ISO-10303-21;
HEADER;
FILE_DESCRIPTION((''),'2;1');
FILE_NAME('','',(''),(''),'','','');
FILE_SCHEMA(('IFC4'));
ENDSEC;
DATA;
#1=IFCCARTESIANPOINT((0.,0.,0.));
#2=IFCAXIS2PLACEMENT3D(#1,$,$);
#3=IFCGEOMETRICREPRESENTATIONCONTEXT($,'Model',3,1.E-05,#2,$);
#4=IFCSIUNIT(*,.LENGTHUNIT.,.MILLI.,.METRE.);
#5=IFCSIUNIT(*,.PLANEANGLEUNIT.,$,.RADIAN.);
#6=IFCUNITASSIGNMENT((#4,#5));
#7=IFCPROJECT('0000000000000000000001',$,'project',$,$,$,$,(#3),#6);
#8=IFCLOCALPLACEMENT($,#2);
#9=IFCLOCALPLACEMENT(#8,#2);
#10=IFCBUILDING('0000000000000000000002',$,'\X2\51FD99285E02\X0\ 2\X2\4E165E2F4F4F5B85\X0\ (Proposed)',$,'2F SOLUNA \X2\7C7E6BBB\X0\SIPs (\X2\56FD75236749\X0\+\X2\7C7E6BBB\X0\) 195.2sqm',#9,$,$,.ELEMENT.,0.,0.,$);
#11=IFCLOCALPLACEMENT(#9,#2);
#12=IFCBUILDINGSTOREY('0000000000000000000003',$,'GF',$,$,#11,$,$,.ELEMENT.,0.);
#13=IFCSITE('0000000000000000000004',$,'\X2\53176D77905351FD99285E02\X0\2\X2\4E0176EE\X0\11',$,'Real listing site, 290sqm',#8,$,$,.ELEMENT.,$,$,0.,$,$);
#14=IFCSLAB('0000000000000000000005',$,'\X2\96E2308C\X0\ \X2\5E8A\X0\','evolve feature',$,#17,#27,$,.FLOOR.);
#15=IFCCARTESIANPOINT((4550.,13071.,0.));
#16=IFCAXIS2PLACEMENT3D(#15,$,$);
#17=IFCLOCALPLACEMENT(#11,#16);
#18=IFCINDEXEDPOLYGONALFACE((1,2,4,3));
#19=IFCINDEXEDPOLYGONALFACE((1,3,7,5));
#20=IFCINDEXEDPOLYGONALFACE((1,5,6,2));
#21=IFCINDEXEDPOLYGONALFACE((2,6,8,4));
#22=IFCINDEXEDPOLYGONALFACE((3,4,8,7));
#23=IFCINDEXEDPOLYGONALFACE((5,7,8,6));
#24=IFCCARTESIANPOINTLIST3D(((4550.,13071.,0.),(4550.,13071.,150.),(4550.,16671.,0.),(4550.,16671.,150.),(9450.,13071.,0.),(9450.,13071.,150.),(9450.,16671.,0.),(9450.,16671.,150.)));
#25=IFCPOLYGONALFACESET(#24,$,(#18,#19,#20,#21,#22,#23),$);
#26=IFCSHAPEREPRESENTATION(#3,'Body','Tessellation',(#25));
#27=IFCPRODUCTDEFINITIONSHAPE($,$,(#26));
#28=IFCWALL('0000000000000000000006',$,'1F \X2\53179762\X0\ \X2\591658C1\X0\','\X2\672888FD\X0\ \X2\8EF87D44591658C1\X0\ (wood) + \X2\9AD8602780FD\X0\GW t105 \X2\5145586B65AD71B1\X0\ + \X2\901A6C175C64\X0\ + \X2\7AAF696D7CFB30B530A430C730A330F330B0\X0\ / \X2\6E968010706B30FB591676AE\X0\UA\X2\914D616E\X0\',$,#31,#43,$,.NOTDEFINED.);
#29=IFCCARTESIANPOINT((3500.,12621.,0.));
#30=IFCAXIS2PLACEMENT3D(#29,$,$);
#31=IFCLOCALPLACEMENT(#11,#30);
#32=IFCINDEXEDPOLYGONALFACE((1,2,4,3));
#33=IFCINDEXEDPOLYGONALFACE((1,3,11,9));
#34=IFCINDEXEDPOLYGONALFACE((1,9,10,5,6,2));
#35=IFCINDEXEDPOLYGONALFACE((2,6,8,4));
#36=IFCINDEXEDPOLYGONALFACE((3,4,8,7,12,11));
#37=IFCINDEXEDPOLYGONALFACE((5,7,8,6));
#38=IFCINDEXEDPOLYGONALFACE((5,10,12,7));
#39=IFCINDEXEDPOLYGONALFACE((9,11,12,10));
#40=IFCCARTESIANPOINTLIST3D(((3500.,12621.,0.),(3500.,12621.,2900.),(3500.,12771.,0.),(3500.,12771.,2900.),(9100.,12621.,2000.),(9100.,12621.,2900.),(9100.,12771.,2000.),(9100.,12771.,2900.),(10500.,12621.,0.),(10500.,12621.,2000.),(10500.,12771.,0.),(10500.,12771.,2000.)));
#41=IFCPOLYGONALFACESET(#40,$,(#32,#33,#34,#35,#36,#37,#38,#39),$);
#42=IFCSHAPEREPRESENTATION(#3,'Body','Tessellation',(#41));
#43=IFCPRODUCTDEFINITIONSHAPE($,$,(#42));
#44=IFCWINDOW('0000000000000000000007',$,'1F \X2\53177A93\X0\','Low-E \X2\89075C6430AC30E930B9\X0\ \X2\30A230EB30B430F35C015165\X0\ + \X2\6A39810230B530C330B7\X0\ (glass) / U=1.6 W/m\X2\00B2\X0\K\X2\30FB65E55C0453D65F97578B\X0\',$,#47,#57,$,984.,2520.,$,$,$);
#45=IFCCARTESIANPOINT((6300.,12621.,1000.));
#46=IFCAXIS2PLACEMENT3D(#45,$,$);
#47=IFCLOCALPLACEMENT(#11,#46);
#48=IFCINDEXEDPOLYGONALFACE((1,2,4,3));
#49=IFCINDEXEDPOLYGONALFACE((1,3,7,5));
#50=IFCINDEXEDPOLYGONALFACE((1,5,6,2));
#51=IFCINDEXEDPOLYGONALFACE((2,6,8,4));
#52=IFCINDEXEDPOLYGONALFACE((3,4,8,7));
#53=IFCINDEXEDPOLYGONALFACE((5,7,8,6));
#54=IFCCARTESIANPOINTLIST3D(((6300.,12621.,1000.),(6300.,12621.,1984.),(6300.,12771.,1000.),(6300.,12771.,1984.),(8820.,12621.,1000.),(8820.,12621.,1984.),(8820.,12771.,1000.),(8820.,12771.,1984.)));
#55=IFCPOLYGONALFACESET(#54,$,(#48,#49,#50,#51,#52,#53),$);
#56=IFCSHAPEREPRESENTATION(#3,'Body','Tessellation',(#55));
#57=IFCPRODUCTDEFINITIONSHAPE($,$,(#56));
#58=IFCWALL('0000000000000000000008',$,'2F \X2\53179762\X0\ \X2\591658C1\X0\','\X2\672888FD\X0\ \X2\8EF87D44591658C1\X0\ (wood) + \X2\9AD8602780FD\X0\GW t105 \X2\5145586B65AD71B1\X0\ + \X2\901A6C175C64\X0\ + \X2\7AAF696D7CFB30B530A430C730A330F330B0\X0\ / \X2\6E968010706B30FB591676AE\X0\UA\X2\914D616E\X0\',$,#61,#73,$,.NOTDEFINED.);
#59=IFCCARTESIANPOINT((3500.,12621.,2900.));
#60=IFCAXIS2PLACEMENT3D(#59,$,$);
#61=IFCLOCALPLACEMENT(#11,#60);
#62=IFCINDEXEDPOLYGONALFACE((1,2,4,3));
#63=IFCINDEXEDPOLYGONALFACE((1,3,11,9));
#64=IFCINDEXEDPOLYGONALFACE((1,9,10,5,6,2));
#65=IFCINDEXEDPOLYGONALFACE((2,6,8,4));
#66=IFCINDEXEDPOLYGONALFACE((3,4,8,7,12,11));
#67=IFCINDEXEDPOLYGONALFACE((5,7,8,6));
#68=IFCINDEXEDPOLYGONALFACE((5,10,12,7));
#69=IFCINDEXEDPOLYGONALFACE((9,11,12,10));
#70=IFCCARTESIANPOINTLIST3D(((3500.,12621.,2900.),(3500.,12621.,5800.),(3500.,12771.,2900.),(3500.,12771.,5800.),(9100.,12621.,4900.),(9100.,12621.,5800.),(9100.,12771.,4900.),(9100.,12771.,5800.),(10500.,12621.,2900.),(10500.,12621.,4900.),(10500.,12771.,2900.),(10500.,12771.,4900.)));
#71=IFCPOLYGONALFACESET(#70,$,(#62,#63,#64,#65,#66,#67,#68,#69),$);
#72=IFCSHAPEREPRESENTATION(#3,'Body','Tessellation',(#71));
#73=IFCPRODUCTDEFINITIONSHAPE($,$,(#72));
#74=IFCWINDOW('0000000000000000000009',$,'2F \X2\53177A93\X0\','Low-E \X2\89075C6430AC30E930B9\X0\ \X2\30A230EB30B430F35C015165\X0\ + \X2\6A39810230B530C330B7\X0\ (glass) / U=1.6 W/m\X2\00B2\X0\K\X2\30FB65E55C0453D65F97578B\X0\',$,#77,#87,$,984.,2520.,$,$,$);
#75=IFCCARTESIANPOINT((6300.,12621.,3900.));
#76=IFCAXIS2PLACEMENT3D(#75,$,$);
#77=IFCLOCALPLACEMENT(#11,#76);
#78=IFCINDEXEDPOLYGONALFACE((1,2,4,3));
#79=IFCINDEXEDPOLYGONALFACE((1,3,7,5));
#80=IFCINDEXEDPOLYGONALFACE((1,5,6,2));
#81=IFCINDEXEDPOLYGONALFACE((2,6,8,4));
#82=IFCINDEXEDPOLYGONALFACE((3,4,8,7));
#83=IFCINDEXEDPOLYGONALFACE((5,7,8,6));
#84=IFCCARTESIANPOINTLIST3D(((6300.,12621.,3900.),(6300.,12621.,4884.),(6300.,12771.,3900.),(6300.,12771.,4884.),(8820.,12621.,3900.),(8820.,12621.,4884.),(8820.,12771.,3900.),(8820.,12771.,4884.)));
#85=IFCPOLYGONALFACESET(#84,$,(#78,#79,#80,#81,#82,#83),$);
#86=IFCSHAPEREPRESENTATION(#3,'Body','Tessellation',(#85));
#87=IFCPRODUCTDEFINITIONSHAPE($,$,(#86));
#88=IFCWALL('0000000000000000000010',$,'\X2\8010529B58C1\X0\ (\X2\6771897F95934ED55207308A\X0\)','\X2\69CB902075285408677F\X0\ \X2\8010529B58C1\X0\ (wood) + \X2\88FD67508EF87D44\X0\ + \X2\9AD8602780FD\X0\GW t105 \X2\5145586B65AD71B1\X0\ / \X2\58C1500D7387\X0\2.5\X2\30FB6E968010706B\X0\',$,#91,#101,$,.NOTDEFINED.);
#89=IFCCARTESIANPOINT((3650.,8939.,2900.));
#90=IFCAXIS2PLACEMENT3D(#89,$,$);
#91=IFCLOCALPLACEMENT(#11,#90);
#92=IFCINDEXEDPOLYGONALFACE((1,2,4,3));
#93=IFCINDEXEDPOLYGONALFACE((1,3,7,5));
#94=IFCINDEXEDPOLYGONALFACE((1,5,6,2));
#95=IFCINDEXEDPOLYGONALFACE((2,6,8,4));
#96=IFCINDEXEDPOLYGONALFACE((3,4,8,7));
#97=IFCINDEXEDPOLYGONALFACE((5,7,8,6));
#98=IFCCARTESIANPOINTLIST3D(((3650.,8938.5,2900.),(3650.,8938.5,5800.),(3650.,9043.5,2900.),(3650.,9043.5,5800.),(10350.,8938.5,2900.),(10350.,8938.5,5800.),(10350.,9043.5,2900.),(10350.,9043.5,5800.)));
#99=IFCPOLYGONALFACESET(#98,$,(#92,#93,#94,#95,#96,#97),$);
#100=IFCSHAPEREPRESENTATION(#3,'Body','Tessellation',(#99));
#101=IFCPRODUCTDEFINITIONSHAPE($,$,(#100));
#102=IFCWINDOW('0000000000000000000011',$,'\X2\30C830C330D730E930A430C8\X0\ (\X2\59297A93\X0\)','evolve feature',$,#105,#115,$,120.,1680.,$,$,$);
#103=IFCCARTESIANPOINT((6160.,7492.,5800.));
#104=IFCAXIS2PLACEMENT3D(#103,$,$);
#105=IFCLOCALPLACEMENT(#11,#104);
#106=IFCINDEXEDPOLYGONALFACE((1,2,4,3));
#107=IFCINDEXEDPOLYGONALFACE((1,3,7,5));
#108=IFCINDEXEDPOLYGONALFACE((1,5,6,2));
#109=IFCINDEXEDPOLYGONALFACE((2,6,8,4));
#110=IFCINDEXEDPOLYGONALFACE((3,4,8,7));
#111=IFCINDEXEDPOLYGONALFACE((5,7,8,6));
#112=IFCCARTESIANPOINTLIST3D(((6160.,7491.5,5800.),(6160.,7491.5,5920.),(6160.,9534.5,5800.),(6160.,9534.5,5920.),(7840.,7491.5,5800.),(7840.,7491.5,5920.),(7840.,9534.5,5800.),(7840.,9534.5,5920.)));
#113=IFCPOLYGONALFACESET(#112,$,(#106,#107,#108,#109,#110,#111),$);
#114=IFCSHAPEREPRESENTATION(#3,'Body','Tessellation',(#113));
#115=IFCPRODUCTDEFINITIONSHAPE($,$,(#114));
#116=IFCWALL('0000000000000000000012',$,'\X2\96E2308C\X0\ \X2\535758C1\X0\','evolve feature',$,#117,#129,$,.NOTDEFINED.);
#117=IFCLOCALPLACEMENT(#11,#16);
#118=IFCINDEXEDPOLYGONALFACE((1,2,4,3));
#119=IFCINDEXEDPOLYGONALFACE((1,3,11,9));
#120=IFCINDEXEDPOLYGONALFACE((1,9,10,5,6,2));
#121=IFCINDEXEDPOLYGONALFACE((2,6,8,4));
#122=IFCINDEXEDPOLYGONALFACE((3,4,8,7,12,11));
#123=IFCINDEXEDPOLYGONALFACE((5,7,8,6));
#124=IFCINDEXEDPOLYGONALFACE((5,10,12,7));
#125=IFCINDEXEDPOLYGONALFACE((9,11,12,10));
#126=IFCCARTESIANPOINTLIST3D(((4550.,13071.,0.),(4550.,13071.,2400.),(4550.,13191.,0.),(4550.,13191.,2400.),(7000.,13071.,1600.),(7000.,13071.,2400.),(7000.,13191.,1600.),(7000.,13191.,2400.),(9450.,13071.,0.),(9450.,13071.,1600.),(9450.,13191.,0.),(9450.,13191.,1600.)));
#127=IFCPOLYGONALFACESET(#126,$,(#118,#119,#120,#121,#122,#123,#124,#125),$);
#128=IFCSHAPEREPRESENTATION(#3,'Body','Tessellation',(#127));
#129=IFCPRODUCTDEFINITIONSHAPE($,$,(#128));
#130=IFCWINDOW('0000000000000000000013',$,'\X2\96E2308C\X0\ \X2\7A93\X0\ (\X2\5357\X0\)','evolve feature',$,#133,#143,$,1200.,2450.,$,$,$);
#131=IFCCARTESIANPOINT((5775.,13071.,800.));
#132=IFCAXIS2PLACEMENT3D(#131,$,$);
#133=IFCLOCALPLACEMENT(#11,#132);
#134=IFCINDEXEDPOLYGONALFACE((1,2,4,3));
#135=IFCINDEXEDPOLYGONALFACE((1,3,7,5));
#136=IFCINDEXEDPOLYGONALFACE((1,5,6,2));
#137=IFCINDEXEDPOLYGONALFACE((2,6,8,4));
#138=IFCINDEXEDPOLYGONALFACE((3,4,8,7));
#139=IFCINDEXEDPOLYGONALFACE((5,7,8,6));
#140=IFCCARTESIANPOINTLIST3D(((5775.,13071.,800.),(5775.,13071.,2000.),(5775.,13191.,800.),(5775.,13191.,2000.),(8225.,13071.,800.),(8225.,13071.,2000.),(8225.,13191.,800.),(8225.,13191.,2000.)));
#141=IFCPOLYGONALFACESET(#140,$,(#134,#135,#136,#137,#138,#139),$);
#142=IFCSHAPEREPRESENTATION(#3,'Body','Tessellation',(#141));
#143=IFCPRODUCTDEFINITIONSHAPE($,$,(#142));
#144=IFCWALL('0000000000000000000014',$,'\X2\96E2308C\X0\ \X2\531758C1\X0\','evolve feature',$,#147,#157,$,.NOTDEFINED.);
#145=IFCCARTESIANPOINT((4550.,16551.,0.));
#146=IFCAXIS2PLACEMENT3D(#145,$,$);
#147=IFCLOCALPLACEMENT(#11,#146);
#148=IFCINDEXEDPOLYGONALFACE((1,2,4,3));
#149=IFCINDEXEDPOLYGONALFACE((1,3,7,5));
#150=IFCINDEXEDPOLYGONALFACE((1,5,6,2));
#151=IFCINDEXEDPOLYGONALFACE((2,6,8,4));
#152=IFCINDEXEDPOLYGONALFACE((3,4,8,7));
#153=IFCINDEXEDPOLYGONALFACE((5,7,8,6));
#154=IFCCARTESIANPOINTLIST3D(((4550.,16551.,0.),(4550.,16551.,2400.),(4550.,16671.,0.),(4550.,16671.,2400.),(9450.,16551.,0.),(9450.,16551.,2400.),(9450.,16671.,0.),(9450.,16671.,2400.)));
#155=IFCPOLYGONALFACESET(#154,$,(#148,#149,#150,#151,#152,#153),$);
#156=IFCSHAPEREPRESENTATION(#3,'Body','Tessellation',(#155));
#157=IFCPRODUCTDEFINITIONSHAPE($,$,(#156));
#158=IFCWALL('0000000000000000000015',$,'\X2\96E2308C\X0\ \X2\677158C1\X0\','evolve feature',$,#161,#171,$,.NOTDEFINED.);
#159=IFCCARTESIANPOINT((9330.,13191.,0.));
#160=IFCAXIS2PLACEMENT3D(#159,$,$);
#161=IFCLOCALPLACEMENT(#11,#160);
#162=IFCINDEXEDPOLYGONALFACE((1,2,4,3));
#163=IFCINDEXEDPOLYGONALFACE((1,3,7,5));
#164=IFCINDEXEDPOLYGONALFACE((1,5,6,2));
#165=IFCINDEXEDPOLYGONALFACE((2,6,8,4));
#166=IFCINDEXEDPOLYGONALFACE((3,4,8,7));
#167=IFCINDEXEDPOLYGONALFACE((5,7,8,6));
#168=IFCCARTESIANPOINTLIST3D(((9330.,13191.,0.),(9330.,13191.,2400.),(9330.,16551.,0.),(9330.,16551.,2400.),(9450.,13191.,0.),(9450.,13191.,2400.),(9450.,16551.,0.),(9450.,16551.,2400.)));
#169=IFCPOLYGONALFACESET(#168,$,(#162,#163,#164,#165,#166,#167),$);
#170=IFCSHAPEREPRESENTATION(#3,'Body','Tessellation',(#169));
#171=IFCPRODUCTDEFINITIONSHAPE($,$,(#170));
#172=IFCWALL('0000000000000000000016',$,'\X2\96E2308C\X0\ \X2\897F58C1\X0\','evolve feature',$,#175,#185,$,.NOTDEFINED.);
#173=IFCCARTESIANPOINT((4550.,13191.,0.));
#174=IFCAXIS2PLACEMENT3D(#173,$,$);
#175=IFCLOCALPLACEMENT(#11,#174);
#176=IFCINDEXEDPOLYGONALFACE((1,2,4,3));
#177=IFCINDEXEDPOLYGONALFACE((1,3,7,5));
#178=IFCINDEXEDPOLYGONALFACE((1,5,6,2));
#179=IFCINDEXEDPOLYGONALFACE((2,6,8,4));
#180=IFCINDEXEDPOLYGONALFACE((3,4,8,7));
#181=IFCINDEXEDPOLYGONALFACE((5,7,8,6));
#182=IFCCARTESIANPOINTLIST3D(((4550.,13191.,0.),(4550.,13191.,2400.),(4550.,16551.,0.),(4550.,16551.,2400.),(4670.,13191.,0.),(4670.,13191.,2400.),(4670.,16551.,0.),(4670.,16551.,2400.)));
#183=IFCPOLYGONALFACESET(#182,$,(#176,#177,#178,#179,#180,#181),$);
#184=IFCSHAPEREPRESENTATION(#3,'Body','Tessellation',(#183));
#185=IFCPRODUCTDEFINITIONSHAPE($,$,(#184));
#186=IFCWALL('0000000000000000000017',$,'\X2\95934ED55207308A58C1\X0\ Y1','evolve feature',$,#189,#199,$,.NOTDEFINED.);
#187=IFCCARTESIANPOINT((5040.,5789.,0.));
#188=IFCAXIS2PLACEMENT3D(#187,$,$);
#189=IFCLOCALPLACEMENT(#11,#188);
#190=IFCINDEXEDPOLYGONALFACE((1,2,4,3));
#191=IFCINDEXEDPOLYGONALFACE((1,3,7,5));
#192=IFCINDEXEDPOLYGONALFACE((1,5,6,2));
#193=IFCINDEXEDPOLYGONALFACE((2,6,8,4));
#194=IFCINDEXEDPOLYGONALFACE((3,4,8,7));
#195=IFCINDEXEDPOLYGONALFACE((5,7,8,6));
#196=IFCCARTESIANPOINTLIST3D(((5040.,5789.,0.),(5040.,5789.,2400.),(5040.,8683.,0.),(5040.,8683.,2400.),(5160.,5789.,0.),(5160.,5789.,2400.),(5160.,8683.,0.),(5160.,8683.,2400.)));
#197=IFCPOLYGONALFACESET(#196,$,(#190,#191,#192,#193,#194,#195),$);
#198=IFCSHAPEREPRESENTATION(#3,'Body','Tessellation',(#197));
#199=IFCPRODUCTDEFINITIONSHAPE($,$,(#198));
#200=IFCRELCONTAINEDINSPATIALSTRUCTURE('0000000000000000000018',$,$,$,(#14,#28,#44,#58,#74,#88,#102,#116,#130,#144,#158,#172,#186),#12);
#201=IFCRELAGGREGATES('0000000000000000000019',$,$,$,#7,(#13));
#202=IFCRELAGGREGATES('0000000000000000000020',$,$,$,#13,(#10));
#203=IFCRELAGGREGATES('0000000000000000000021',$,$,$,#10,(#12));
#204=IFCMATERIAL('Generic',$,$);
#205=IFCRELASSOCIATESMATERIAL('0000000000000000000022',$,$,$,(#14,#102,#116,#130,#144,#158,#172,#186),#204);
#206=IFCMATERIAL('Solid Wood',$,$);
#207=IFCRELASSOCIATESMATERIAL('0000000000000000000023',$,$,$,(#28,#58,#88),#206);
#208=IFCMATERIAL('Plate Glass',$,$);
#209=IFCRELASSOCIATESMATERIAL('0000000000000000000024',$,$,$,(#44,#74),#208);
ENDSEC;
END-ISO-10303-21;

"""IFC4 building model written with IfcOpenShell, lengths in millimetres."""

from ifc_helpers import new_model, si_unit, frame, frame_2d, origin, place, context, project, spatial, rectangle, extrude, material, element, fill, save


model = new_model("IFC4")

# Units and contexts
model_context = context("Model", 3, precision=1e-05, world=origin())
ifc_project = project(units=[si_unit("LENGTHUNIT", "METRE", prefix="MILLI"), si_unit("PLANEANGLEUNIT", "RADIAN")], contexts=[model_context])

# Site, building, storey
site_placement = place(None, origin())
site = spatial("IfcSite", under=ifc_project, at=site_placement, Name="北海道函館市2丁目11", ObjectType="Real listing site, 290sqm", CompositionType="ELEMENT", RefElevation=0.0)
building_placement = place(site_placement, origin())
building = spatial("IfcBuilding", under=site, at=building_placement, Name="函館市 2世帯住宅 (Proposed)", ObjectType="2F SOLUNA 籾殻SIPs (国産杉+籾殻) 195.2sqm", CompositionType="ELEMENT", ElevationOfRefHeight=0.0, ElevationOfTerrain=0.0)
storey_placement = place(building_placement, origin())
storey = spatial("IfcBuildingStorey", under=building, at=storey_placement, Name="GF", CompositionType="ELEMENT", Elevation=0.0)

# Slab
ifc_material_1 = material(Name="Generic")
slab_placement = place(storey_placement, frame((4550.0, 13071.0, 0.0)))
element("IfcSlab", 1, at=slab_placement, inside=storey, material=ifc_material_1, Name="離れ 床", Description="evolve feature", PredefinedType="FLOOR", context=model_context, shape_type="SweptSolid", body=[
    extrude(rectangle(XDim=4900.0, YDim=3600.0, at=frame_2d((2450.0, 1800.0))), frame((4550.0, 13071.0, 0.0)), (0.0, 0.0, 1.0), 150.0),
])

# Wall, opening, window
ifc_material_2 = material(Name="Solid Wood")
wall_1_placement = place(storey_placement, frame((3500.0, 12621.0, 0.0)))
wall_1 = element("IfcWall", 2, at=wall_1_placement, inside=storey, material=ifc_material_2, Name="1F 北面 外壁", Description="木製 軸組外壁 (wood) + 高性能GW t105 充填断熱 + 通気層 + 窯業系サイディング / 準耐火・外皮UA配慮", PredefinedType="NOTDEFINED", context=model_context, shape_type="SweptSolid", body=[
    extrude(rectangle(XDim=7000.0, YDim=150.0, at=frame_2d((3500.0, 75.0))), frame((3500.0, 12621.0, 0.0)), (0.0, 0.0, 1.0), 2900.0),
])
opening_1_placement = place(storey_placement, frame((6300.0, 12621.0, 1000.0)))
opening_1 = element("IfcOpeningElement", 3, at=opening_1_placement, cuts=wall_1, PredefinedType="NOTDEFINED", context=model_context, shape_type="SweptSolid", body=[
    extrude(rectangle(XDim=2520.0, YDim=150.0, at=frame_2d((1260.0, 75.0))), frame((6300.0, 12621.0, 1000.0)), (0.0, 0.0, 1.0), 984.0),
])
ifc_material_3 = material(Name="Plate Glass")
window_1_placement = place(storey_placement, frame((6300.0, 12621.0, 1000.0)))
window_1 = element("IfcWindow", 4, at=window_1_placement, inside=storey, material=ifc_material_3, Name="1F 北窓", Description="Low-E 複層ガラス アルゴン封入 + 樹脂サッシ (glass) / U=1.6 W/m²K・日射取得型", OverallHeight=984.0, OverallWidth=2520.0, context=model_context, shape_type="SweptSolid", body=[
    extrude(rectangle(XDim=2520.0, YDim=150.0, at=frame_2d((1260.0, 75.0))), frame((6300.0, 12621.0, 1000.0)), (0.0, 0.0, 1.0), 984.0),
])
fill(opening_1, window_1)

# Wall, opening, window
wall_2_placement = place(storey_placement, frame((3500.0, 12621.0, 2900.0)))
wall_2 = element("IfcWall", 5, at=wall_2_placement, inside=storey, material=ifc_material_2, Name="2F 北面 外壁", Description="木製 軸組外壁 (wood) + 高性能GW t105 充填断熱 + 通気層 + 窯業系サイディング / 準耐火・外皮UA配慮", PredefinedType="NOTDEFINED", context=model_context, shape_type="SweptSolid", body=[
    extrude(rectangle(XDim=7000.0, YDim=150.0, at=frame_2d((3500.0, 75.0))), frame((3500.0, 12621.0, 2900.0)), (0.0, 0.0, 1.0), 2900.0),
])
opening_2_placement = place(storey_placement, frame((6300.0, 12621.0, 3900.0)))
opening_2 = element("IfcOpeningElement", 6, at=opening_2_placement, cuts=wall_2, PredefinedType="NOTDEFINED", context=model_context, shape_type="SweptSolid", body=[
    extrude(rectangle(XDim=2520.0, YDim=150.0, at=frame_2d((1260.0, 75.0))), frame((6300.0, 12621.0, 3900.0)), (0.0, 0.0, 1.0), 984.0),
])
window_2_placement = place(storey_placement, frame((6300.0, 12621.0, 3900.0)))
window_2 = element("IfcWindow", 7, at=window_2_placement, inside=storey, material=ifc_material_3, Name="2F 北窓", Description="Low-E 複層ガラス アルゴン封入 + 樹脂サッシ (glass) / U=1.6 W/m²K・日射取得型", OverallHeight=984.0, OverallWidth=2520.0, context=model_context, shape_type="SweptSolid", body=[
    extrude(rectangle(XDim=2520.0, YDim=150.0, at=frame_2d((1260.0, 75.0))), frame((6300.0, 12621.0, 3900.0)), (0.0, 0.0, 1.0), 984.0),
])
fill(opening_2, window_2)

# Wall
wall_3_placement = place(storey_placement, frame((3650.0, 8939.0, 2900.0)))
element("IfcWall", 8, at=wall_3_placement, inside=storey, material=ifc_material_2, Name="耐力壁 (東西間仕切り)", Description="構造用合板 耐力壁 (wood) + 製材軸組 + 高性能GW t105 充填断熱 / 壁倍率2.5・準耐火", PredefinedType="NOTDEFINED", context=model_context, shape_type="SweptSolid", body=[
    extrude(rectangle(XDim=6700.0, YDim=105.0, at=frame_2d((3350.0, 52.0))), frame((3650.0, 8939.0, 2900.0)), (0.0, 0.0, 1.0), 2900.0),
])

# Window
window_3_placement = place(storey_placement, frame((6160.0, 7492.0, 5800.0)))
element("IfcWindow", 9, at=window_3_placement, inside=storey, material=ifc_material_1, Name="トップライト (天窓)", Description="evolve feature", OverallHeight=120.0, OverallWidth=1680.0, context=model_context, shape_type="SweptSolid", body=[
    extrude(rectangle(XDim=1680.0, YDim=2043.0, at=frame_2d((840.0, 1021.0))), frame((6160.0, 7492.0, 5800.0)), (0.0, 0.0, 1.0), 120.0),
])

# Wall, opening, window
wall_4_placement = place(storey_placement, frame((4550.0, 13071.0, 0.0)))
wall_4 = element("IfcWall", 10, at=wall_4_placement, inside=storey, material=ifc_material_1, Name="離れ 南壁", Description="evolve feature", PredefinedType="NOTDEFINED", context=model_context, shape_type="SweptSolid", body=[
    extrude(rectangle(XDim=4900.0, YDim=120.0, at=frame_2d((2450.0, 60.0))), frame((4550.0, 13071.0, 0.0)), (0.0, 0.0, 1.0), 2400.0),
])
opening_3_placement = place(storey_placement, frame((5775.0, 13071.0, 800.0)))
opening_3 = element("IfcOpeningElement", 11, at=opening_3_placement, cuts=wall_4, PredefinedType="NOTDEFINED", context=model_context, shape_type="SweptSolid", body=[
    extrude(rectangle(XDim=2450.0, YDim=120.0, at=frame_2d((1225.0, 60.0))), frame((5775.0, 13071.0, 800.0)), (0.0, 0.0, 1.0), 1200.0),
])
window_4_placement = place(storey_placement, frame((5775.0, 13071.0, 800.0)))
window_4 = element("IfcWindow", 12, at=window_4_placement, inside=storey, material=ifc_material_1, Name="離れ 窓 (南)", Description="evolve feature", OverallHeight=1200.0, OverallWidth=2450.0, context=model_context, shape_type="SweptSolid", body=[
    extrude(rectangle(XDim=2450.0, YDim=120.0, at=frame_2d((1225.0, 60.0))), frame((5775.0, 13071.0, 800.0)), (0.0, 0.0, 1.0), 1200.0),
])
fill(opening_3, window_4)

# Walls
wall_5_placement = place(storey_placement, frame((4550.0, 16551.0, 0.0)))
element("IfcWall", 13, at=wall_5_placement, inside=storey, material=ifc_material_1, Name="離れ 北壁", Description="evolve feature", PredefinedType="NOTDEFINED", context=model_context, shape_type="SweptSolid", body=[
    extrude(rectangle(XDim=4900.0, YDim=120.0, at=frame_2d((2450.0, 60.0))), frame((4550.0, 16551.0, 0.0)), (0.0, 0.0, 1.0), 2400.0),
])
wall_6_placement = place(storey_placement, frame((9330.0, 13191.0, 0.0)))
element("IfcWall", 14, at=wall_6_placement, inside=storey, material=ifc_material_1, Name="離れ 東壁", Description="evolve feature", PredefinedType="NOTDEFINED", context=model_context, shape_type="SweptSolid", body=[
    extrude(rectangle(XDim=120.0, YDim=3360.0, at=frame_2d((60.0, 1680.0))), frame((9330.0, 13191.0, 0.0)), (0.0, 0.0, 1.0), 2400.0),
])
wall_7_placement = place(storey_placement, frame((4550.0, 13191.0, 0.0)))
element("IfcWall", 15, at=wall_7_placement, inside=storey, material=ifc_material_1, Name="離れ 西壁", Description="evolve feature", PredefinedType="NOTDEFINED", context=model_context, shape_type="SweptSolid", body=[
    extrude(rectangle(XDim=120.0, YDim=3360.0, at=frame_2d((60.0, 1680.0))), frame((4550.0, 13191.0, 0.0)), (0.0, 0.0, 1.0), 2400.0),
])
wall_8_placement = place(storey_placement, frame((5040.0, 5789.0, 0.0)))
element("IfcWall", 16, at=wall_8_placement, inside=storey, material=ifc_material_1, Name="間仕切り壁 Y1", Description="evolve feature", PredefinedType="NOTDEFINED", context=model_context, shape_type="SweptSolid", body=[
    extrude(rectangle(XDim=120.0, YDim=2894.0, at=frame_2d((60.0, 1447.0))), frame((5040.0, 5789.0, 0.0)), (0.0, 0.0, 1.0), 2400.0),
])

save(model, "model.ifc")
